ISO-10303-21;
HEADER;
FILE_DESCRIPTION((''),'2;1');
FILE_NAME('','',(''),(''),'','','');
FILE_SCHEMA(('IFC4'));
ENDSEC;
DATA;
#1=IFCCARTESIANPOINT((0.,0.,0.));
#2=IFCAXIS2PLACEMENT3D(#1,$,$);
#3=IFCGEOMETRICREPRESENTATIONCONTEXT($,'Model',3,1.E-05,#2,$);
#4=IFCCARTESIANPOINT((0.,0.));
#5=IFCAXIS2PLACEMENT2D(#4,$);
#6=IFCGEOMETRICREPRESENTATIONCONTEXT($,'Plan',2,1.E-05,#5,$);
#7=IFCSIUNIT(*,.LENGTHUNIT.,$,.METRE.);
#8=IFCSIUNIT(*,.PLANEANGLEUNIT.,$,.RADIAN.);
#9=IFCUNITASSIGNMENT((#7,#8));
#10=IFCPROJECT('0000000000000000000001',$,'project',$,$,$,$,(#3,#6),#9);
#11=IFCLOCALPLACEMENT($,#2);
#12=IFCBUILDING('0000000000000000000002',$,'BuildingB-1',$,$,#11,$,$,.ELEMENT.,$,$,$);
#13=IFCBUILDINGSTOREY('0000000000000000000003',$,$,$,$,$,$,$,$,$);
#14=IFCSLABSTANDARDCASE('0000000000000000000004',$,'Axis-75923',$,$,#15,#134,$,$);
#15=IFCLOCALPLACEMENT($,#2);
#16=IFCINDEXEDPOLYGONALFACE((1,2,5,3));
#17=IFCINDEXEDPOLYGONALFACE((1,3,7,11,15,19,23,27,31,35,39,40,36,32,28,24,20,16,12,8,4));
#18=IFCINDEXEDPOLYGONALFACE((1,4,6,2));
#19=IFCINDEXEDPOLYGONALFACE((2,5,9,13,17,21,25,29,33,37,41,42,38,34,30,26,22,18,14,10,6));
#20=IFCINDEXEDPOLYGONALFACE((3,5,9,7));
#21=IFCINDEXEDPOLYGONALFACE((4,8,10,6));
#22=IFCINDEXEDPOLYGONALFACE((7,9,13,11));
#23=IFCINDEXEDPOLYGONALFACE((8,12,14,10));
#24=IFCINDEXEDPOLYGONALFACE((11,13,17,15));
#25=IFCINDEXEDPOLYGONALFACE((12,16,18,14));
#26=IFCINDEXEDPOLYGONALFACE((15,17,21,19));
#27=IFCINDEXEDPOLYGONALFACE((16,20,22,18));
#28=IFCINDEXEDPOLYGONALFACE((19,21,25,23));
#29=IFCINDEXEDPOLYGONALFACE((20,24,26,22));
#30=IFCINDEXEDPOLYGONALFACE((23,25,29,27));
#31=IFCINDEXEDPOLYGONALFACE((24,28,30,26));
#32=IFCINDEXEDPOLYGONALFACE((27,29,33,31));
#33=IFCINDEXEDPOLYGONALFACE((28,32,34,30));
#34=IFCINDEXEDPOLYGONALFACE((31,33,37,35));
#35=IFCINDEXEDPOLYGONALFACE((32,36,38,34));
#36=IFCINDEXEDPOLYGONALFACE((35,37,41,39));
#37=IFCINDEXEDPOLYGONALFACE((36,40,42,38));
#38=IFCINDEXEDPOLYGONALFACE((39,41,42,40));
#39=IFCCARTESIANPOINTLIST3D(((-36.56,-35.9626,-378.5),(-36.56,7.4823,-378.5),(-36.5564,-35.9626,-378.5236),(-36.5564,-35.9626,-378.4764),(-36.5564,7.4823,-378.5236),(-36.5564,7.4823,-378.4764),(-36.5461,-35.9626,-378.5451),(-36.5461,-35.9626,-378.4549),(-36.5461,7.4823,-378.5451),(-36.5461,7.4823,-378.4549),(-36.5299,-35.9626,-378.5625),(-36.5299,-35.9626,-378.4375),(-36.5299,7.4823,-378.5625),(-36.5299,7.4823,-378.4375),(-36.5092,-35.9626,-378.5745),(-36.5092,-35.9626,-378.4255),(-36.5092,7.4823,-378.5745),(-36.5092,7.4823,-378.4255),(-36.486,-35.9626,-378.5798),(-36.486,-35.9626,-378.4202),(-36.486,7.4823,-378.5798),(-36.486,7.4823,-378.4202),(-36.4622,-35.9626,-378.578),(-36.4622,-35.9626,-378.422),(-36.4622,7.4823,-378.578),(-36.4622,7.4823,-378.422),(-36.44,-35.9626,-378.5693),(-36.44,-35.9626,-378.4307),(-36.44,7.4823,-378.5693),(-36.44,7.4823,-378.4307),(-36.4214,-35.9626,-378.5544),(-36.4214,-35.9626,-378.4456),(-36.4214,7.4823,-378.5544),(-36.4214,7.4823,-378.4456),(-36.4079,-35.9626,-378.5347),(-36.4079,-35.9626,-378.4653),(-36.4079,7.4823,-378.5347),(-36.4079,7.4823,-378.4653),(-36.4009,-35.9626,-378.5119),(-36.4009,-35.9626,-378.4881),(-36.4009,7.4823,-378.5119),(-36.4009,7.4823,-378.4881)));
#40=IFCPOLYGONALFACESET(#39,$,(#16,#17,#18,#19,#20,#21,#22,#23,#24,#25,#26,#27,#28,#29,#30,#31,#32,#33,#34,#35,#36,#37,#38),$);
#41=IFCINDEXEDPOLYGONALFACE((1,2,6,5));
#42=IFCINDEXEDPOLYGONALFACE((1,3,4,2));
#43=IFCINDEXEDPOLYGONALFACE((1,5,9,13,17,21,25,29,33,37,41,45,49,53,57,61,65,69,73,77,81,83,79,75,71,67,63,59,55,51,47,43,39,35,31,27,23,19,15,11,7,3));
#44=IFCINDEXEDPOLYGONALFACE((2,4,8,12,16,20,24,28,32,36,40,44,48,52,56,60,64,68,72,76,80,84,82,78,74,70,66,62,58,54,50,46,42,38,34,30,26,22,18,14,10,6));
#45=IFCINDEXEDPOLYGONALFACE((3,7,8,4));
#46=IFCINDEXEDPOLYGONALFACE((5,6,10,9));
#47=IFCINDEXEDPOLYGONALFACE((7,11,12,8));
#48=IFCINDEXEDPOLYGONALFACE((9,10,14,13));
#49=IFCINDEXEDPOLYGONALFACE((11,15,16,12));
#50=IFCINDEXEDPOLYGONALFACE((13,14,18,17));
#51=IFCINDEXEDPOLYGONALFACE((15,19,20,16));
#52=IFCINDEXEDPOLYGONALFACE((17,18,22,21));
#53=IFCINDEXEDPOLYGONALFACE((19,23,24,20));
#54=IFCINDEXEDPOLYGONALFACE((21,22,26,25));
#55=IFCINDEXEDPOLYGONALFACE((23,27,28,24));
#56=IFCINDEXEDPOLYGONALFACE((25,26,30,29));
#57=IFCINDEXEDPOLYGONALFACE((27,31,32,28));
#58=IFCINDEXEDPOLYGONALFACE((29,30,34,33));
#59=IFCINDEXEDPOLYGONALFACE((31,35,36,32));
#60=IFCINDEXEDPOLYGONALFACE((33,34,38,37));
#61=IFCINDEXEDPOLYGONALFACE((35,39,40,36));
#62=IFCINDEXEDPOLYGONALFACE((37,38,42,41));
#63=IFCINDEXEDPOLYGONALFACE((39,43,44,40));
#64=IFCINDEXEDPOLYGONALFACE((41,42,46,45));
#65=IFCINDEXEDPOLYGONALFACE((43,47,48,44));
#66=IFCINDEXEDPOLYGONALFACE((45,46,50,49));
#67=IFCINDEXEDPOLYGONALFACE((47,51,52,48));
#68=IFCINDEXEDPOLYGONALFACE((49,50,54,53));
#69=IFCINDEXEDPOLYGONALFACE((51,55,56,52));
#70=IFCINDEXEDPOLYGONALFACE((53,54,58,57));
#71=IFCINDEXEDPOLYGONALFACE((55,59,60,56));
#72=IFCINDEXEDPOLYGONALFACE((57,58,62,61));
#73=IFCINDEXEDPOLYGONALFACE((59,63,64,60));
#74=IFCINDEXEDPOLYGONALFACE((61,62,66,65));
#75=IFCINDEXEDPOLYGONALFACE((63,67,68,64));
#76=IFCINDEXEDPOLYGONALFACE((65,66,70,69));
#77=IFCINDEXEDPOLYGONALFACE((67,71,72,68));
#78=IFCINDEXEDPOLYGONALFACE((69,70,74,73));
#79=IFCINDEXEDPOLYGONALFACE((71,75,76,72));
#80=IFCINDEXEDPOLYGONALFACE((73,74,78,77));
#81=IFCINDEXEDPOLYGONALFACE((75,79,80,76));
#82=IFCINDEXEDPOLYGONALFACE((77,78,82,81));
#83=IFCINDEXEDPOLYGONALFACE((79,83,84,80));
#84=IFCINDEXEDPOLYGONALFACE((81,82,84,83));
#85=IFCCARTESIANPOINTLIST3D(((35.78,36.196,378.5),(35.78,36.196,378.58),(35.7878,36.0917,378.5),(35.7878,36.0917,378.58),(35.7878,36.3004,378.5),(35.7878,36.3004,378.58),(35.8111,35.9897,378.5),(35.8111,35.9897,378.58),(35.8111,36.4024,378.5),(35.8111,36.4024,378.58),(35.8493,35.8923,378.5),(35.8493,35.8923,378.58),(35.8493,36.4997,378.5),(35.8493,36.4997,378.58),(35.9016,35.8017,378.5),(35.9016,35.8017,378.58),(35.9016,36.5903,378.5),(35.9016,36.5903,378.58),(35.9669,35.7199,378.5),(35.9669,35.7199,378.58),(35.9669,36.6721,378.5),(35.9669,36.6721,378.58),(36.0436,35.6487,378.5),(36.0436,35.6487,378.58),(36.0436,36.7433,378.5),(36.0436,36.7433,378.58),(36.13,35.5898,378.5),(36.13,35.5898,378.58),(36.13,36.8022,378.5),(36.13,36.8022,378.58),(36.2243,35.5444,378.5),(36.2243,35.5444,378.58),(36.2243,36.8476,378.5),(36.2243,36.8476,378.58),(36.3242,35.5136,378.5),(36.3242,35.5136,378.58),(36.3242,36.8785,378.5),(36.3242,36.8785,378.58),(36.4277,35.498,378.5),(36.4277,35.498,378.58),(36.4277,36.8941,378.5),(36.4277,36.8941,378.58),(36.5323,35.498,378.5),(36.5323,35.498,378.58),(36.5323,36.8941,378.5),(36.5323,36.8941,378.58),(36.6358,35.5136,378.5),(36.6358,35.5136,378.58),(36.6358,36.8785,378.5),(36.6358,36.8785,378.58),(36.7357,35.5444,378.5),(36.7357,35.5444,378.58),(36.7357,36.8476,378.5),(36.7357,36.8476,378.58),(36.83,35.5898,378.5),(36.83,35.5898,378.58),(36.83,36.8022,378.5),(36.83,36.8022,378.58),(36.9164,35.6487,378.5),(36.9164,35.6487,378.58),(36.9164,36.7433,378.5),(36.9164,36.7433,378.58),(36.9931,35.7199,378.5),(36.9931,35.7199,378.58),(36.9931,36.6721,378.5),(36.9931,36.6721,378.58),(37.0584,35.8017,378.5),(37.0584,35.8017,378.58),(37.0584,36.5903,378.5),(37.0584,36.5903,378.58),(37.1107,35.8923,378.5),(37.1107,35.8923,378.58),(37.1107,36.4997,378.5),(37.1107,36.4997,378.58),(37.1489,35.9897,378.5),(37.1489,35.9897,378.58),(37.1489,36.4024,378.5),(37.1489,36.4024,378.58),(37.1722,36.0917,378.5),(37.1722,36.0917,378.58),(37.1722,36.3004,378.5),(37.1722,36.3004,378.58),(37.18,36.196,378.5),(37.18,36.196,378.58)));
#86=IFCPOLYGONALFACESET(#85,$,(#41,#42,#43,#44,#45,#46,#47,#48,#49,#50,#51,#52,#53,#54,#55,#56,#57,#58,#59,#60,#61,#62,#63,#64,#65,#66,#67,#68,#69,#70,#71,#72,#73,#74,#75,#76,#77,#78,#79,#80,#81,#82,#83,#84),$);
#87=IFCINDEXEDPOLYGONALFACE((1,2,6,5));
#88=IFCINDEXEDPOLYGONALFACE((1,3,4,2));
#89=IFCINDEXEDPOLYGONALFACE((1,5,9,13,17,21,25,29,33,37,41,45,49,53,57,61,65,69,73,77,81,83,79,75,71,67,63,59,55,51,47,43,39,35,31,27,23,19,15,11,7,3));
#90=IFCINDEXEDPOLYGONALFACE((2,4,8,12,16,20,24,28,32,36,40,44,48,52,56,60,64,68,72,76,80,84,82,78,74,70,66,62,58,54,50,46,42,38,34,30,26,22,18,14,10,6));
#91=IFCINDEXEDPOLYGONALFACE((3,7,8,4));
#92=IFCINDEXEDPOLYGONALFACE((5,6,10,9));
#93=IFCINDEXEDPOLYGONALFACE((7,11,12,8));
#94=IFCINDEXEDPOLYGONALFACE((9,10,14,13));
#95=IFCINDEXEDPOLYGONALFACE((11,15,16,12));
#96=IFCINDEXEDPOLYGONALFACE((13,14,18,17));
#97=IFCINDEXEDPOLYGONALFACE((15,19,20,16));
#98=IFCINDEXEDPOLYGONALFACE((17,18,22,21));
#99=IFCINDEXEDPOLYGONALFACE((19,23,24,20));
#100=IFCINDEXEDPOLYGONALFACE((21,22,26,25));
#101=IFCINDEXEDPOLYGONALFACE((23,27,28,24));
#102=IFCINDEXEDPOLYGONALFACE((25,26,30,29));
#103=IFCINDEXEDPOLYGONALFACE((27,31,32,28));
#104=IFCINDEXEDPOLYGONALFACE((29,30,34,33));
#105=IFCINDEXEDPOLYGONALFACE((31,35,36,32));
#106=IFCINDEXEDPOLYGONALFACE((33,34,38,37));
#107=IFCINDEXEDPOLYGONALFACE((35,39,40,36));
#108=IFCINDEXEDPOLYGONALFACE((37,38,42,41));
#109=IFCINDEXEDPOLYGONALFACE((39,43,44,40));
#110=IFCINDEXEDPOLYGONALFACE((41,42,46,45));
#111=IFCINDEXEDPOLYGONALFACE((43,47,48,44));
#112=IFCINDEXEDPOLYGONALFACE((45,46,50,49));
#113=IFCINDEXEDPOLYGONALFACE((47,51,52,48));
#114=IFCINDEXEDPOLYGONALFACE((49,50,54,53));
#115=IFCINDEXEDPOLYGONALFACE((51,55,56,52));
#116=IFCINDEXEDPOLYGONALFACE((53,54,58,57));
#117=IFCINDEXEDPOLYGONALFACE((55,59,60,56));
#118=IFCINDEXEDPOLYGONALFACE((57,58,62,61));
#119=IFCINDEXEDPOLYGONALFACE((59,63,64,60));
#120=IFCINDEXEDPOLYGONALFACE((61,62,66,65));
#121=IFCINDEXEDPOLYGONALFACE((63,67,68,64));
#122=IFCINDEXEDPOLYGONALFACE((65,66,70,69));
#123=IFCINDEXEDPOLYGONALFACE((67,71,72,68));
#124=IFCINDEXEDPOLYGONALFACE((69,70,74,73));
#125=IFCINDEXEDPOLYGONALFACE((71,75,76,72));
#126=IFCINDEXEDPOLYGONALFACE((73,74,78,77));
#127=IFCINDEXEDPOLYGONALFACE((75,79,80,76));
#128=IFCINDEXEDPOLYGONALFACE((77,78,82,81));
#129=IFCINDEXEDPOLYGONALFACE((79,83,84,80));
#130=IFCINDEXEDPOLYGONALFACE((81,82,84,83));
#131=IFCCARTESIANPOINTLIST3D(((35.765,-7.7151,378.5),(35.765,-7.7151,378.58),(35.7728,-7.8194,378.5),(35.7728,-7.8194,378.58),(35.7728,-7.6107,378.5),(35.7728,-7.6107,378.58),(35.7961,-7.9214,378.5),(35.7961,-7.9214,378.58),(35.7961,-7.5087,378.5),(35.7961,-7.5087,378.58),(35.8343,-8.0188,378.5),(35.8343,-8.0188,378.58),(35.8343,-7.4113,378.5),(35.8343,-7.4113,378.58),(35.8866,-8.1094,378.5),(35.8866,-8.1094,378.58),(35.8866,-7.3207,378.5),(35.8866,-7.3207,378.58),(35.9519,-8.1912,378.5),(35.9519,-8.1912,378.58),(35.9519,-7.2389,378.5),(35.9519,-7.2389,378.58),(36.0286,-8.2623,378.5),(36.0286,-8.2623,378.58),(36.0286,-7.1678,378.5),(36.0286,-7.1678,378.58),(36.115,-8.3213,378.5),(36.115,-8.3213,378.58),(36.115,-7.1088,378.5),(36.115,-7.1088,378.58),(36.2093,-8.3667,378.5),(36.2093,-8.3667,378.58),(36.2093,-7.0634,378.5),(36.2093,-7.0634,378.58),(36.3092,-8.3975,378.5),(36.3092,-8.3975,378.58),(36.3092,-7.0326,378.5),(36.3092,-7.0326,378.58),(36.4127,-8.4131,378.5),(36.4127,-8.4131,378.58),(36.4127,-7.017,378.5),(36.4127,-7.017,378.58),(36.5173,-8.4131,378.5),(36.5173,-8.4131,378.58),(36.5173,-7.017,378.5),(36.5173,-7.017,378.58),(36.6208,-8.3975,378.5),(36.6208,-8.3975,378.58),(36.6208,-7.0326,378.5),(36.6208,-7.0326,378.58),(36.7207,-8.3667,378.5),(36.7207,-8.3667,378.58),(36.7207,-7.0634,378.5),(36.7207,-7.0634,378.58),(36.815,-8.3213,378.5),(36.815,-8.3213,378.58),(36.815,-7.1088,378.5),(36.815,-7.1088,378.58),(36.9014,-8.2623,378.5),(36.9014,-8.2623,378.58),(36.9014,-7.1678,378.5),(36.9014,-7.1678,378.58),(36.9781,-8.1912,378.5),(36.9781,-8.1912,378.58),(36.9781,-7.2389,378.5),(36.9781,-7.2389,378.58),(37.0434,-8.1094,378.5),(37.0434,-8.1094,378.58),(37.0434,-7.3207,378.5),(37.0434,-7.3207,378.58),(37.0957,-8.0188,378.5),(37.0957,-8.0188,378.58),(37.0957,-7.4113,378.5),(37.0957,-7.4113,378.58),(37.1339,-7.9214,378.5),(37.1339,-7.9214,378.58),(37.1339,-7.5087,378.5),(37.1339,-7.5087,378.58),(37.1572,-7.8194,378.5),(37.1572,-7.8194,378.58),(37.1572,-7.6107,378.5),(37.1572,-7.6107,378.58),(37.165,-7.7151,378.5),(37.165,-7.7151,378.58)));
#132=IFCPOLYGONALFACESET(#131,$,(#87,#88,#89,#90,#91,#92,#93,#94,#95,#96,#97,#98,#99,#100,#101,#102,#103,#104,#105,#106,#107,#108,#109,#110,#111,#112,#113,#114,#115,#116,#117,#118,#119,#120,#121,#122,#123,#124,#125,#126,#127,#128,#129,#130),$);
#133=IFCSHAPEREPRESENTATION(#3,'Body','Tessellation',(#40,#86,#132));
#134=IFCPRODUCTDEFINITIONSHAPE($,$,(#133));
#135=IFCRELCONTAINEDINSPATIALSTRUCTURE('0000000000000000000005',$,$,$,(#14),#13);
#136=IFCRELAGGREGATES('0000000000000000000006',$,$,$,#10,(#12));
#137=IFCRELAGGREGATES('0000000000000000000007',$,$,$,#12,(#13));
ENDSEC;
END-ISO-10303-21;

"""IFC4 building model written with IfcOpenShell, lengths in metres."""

from ifc_helpers import new_model, entity, si_unit, frame, origin, origin_2d, place, context, project, spatial, circle, extrude, element, save


model = new_model("IFC4")

# Units and contexts
model_context = context("Model", 3, precision=1e-05, world=origin())
plan_context = context("Plan", 2, precision=1e-05, world=origin_2d())
ifc_project = project(units=[si_unit("LENGTHUNIT", "METRE"), si_unit("PLANEANGLEUNIT", "RADIAN")], contexts=[model_context, plan_context])

# Building, storey
building_placement = place(None, origin())
building = spatial("IfcBuilding", under=ifc_project, at=building_placement, Name="BuildingB-1", CompositionType="ELEMENT")
storey = spatial("IfcBuildingStorey", under=building)

# Slab
element("IfcSlabStandardCase", 1, inside=storey, Name="Axis-75923", context=model_context, shape_type="AdvancedSweptSolid", body=[
    entity("IfcSurfaceCurveSweptAreaSolid", entity("IfcCircleProfileDef", "AREA", None, None, 0.08), None, entity("IfcPolyline", [entity("IfcCartesianPoint", [36.48, 35.9626, 378.5]), entity("IfcCartesianPoint", [36.48, -7.4823, 378.5])]), None, None, entity("IfcPlane", entity("IfcAxis2Placement3D", entity("IfcCartesianPoint", [36.48, 35.9626, 378.5]), entity("IfcDirection", [0.0, 0.0, 1.0]), entity("IfcDirection", [1.0, 0.0, 0.0])))),
    extrude(circle(Radius=0.7), frame((36.48, 36.196, 378.5)), (0.0, 0.0, 1.0), 0.08),
    extrude(circle(Radius=0.7), frame((36.465, -7.7151, 378.5)), (0.0, 0.0, 1.0), 0.08),
])

save(model, "model.ifc")
